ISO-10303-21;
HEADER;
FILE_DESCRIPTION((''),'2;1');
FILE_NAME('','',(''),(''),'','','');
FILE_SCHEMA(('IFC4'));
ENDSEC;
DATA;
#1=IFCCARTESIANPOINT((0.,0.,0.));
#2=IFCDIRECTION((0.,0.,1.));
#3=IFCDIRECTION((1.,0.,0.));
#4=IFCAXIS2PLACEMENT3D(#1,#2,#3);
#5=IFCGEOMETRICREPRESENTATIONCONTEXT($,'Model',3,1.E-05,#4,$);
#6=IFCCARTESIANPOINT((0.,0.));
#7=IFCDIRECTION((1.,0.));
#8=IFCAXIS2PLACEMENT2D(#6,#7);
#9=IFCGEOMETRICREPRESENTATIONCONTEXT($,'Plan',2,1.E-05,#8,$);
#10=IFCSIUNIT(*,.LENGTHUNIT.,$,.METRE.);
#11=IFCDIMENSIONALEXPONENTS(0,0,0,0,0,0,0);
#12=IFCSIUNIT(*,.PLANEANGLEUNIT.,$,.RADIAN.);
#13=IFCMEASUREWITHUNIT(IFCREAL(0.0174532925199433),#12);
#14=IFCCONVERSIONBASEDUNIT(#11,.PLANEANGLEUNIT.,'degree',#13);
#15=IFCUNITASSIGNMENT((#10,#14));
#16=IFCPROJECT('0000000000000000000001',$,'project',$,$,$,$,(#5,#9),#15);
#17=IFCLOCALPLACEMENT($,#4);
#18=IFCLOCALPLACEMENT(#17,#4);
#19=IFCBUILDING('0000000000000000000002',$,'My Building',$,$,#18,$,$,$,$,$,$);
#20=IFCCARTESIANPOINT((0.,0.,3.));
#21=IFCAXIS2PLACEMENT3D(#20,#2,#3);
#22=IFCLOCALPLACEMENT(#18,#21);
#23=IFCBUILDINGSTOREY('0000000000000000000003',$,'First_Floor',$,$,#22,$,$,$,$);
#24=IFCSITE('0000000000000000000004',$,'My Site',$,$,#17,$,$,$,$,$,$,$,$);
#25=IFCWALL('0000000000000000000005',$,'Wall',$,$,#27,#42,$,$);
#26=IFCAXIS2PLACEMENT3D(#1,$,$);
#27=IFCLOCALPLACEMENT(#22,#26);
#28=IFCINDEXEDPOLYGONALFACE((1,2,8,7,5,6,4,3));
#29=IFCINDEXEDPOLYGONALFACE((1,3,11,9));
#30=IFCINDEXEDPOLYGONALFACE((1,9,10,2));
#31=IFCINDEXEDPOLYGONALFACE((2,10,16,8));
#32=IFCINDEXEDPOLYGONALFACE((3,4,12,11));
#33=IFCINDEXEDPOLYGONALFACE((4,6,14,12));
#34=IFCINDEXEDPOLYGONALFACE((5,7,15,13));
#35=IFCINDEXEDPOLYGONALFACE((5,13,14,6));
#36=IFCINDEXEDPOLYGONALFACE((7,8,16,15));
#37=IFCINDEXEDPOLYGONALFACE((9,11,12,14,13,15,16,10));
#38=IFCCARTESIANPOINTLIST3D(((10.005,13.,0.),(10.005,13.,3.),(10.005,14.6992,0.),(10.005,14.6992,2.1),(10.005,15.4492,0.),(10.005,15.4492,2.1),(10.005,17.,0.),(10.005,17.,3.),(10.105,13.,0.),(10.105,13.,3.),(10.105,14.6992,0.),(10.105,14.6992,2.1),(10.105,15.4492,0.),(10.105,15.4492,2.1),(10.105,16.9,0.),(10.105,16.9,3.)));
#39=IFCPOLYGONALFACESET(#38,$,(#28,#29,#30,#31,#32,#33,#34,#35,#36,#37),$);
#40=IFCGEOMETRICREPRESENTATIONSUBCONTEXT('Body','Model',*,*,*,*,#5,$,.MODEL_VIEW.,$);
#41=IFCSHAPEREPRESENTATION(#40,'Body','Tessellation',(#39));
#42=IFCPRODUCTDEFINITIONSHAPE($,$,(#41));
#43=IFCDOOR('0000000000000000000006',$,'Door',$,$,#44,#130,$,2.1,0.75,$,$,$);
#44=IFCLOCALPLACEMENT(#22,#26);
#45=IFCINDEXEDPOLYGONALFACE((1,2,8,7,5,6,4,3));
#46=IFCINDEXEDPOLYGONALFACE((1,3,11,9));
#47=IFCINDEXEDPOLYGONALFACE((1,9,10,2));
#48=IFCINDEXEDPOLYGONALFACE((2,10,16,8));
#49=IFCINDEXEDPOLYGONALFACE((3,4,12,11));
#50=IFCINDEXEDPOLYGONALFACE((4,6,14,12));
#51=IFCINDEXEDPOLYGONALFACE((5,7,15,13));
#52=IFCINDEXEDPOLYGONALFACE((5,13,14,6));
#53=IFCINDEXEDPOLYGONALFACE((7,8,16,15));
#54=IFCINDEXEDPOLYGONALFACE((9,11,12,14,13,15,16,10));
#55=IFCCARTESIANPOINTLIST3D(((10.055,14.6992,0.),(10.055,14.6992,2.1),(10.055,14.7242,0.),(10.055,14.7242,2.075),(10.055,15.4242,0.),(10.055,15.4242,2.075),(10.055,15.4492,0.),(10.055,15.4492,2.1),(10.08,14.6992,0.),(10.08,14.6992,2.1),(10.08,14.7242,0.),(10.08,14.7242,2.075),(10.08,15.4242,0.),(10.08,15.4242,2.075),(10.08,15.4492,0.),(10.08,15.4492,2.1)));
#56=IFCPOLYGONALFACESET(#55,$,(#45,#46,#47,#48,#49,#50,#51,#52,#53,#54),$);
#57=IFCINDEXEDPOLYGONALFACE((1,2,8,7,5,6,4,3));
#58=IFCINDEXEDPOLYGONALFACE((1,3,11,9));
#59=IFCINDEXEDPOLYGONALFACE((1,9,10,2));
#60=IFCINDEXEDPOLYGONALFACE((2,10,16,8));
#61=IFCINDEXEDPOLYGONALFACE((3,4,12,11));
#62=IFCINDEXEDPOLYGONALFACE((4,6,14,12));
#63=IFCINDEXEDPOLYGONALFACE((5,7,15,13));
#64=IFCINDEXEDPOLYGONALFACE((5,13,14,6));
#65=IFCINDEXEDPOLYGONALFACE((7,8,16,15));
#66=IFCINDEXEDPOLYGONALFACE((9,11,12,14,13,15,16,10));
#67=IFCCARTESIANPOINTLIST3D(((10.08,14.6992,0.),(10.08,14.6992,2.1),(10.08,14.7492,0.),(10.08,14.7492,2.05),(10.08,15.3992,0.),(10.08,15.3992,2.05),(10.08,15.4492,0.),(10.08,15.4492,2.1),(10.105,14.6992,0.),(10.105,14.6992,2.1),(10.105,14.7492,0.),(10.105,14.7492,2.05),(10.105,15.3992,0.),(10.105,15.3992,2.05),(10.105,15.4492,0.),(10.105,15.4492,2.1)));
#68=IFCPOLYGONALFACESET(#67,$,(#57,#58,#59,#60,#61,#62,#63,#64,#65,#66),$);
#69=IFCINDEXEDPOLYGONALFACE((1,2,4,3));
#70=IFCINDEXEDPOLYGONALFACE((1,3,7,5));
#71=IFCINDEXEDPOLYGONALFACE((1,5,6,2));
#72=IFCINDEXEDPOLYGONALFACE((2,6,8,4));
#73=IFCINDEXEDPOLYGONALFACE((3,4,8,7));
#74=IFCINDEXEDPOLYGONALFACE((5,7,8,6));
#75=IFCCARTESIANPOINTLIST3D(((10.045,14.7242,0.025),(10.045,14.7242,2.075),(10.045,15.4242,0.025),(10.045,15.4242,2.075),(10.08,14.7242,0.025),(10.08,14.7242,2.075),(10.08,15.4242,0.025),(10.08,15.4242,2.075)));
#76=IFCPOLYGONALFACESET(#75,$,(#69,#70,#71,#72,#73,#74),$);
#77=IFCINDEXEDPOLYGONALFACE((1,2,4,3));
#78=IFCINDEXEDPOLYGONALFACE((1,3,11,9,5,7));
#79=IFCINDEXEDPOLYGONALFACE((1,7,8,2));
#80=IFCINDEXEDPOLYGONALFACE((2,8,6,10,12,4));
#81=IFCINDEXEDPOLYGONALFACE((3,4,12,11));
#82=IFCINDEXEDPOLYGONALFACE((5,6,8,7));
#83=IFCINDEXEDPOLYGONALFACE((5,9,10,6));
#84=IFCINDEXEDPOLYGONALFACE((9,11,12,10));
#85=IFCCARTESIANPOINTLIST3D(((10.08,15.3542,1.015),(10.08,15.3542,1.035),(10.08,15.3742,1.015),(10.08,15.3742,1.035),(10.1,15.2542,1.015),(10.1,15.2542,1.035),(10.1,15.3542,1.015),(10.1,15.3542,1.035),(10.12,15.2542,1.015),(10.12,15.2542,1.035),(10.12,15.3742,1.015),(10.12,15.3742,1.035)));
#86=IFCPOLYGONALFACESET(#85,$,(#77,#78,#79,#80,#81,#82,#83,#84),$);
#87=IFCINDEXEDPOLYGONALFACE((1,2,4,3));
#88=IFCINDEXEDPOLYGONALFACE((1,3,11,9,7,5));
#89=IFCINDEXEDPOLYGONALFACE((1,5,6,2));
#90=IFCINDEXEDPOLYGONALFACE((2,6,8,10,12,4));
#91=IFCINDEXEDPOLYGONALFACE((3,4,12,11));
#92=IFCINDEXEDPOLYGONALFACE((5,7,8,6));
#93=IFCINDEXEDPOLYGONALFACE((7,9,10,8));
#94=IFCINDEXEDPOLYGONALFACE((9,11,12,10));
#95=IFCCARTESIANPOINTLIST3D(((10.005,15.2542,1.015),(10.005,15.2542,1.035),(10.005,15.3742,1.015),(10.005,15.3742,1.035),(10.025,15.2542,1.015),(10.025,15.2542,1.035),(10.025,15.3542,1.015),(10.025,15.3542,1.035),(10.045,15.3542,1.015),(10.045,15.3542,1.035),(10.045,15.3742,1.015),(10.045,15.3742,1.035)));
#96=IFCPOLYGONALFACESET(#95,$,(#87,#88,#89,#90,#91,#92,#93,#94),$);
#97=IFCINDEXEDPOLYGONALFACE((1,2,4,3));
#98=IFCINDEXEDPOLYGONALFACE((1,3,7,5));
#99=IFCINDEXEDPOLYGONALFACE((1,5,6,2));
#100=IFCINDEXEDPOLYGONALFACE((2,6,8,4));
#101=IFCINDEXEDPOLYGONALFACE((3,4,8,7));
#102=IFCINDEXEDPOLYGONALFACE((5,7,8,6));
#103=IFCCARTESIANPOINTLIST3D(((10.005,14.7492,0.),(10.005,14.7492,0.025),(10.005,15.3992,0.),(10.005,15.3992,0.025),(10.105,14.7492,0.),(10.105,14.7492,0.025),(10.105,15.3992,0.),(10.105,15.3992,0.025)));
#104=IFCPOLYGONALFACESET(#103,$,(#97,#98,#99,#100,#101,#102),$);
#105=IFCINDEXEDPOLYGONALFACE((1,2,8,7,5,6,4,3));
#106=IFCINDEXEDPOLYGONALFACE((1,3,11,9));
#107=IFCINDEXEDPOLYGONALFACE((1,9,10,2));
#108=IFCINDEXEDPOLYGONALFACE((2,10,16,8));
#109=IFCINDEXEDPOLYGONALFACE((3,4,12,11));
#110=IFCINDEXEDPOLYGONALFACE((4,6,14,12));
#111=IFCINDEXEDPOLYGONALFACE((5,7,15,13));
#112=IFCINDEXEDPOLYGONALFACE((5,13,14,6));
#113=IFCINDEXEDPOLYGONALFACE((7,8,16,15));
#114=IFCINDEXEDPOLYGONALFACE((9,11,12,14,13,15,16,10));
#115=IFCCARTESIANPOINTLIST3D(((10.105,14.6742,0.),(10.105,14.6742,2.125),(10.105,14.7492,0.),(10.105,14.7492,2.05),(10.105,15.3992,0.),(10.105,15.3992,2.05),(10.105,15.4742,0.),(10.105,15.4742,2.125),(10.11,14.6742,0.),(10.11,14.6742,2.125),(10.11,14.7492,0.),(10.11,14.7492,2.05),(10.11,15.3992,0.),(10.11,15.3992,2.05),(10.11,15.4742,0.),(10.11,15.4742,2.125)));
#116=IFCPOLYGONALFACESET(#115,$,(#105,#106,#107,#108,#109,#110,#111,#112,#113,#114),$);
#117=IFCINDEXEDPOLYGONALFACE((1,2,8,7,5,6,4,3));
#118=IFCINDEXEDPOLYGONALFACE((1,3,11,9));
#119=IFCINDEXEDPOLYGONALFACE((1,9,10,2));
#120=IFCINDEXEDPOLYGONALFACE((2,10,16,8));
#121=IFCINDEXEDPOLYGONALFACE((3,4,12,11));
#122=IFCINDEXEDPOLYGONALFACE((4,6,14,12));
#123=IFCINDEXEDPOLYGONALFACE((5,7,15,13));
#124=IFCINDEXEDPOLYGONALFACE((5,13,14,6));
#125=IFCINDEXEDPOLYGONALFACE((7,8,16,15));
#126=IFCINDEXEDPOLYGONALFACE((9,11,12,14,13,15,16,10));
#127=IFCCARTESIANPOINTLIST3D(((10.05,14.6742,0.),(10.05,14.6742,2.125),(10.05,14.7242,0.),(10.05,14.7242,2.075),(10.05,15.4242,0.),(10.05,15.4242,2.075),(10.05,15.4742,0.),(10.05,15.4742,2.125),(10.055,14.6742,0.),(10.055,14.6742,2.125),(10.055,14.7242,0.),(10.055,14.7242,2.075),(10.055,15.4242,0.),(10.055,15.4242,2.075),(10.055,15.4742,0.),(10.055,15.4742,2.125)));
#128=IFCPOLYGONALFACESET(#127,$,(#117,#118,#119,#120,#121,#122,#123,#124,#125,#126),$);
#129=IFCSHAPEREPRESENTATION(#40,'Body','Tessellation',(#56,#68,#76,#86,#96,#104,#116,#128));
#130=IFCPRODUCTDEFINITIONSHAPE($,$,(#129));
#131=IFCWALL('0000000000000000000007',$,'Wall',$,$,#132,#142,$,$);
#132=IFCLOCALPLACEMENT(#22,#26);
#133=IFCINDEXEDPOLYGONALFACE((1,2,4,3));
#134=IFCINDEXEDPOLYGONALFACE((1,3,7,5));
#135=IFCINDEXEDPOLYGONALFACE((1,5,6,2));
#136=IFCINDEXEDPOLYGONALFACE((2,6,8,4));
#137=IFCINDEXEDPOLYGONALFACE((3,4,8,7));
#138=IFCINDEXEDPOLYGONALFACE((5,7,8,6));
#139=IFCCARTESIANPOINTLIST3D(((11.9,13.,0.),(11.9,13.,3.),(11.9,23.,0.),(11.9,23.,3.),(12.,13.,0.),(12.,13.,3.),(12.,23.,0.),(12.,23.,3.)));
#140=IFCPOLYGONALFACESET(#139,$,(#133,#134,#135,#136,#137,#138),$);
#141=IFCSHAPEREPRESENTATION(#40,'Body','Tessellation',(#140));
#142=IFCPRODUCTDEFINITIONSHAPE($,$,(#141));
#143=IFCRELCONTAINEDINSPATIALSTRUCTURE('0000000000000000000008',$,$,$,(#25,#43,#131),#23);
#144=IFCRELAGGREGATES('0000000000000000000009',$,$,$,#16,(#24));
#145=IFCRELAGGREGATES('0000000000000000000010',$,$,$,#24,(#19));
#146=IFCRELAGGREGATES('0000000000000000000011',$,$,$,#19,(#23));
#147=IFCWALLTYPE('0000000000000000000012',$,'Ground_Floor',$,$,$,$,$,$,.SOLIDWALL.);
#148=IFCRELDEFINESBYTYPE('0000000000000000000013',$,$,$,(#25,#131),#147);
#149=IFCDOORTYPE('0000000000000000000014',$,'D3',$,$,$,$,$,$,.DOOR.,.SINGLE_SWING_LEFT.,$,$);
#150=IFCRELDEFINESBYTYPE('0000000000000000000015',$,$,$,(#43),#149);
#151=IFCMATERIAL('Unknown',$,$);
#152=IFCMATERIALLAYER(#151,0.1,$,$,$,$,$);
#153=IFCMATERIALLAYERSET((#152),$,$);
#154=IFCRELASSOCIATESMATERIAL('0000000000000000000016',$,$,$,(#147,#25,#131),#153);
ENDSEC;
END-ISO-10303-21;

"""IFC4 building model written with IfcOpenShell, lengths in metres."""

from ifc_helpers import new_model, entity, si_unit, converted_unit, frame, origin_with_axes, origin_2d_with_axis, place, context, subcontext, project, spatial, line, indexed_curve, outline, extrude, shape, source, transform, mapped, material, layer, layer_set, layer_usage, type_object, type_shapes, element, fill, save


model = new_model("IFC4")

# Units and contexts
model_context = context("Model", 3, precision=1e-05, world=origin_with_axes())
plan_context = context("Plan", 2, precision=1e-05, world=origin_2d_with_axis())
body_context_1 = subcontext(model_context, "Body", "Model", "MODEL_VIEW")
body_context_2 = subcontext(plan_context, "Body", "Plan", "PLAN_VIEW")
ifc_project = project(units=[si_unit("LENGTHUNIT", "METRE"), converted_unit("PLANEANGLEUNIT", "degree", entity("IfcReal", 0.0174532925199433), si_unit("PLANEANGLEUNIT", "RADIAN"), dimensions=[0, 0, 0, 0, 0, 0, 0])], contexts=[model_context, plan_context])

# Site, building, storey
site_placement = place(None, origin_with_axes())
site = spatial("IfcSite", under=ifc_project, at=site_placement, Name="My Site")
building_placement = place(site_placement, origin_with_axes())
building = spatial("IfcBuilding", under=site, at=building_placement, Name="My Building")
storey_placement = place(building_placement, frame((0.0, 0.0, 3.0), z_axis=(0.0, 0.0, 1.0), x_axis=(1.0, 0.0, 0.0)))
storey = spatial("IfcBuildingStorey", under=building, at=storey_placement, Name="First_Floor")

# Shared definitions
ifc_material = material(Name="Unknown")

# Wall, opening, door
ifc_layer = layer(ifc_material, 0.1)
ifc_layer_set = layer_set([ifc_layer])
wall_type = type_object("IfcWallType", Name="Ground_Floor", PredefinedType="SOLIDWALL", material=ifc_layer_set)
ifc_layer_usage_1 = layer_usage(ifc_layer_set, "AXIS2", "POSITIVE", 0.0)
wall_1_placement = place(storey_placement, frame((10.005, 17.0, 0.0), z_axis=(0.0, 0.0, 1.0), x_axis=(0.0, -1.0, 0.0)))
wall_1 = element("IfcWall", 1, at=wall_1_placement, inside=storey, type_object=wall_type, material=ifc_layer_usage_1, Name="Wall", context=body_context_1, shape_type="SweptSolid", body=[
    extrude(outline(indexed_curve([(0.0, 0.0), (0.1, 0.1), (4.0, 0.1), (4.0, 0.0)], segments=[line(1, 2, 3, 4, 1)])), origin_with_axes(), (0.0, 0.0, 1.0), 3.0),
])
shared_shape_1 = source(origin_with_axes(), body_context_1, "Body", "SweptSolid", [
    extrude(outline(indexed_curve([(0.0, 0.0), (0.75, 0.0), (0.75, 2.1), (0.0, 2.1)], segments=[line(1, 2, 3, 4, 1)])), frame((0.0, -0.6, 0.0), z_axis=(0.0, -1.0, 0.0), x_axis=(1.0, 0.0, 0.0)), (0.0, 0.0, -1.0), 1.2),
])
opening_1_placement = place(wall_1_placement, frame((2.3008, 0.1, 0.0), z_axis=(0.0, 0.0, 1.0), x_axis=(-1.0, 0.0, 0.0)))
opening_1 = element("IfcOpeningElement", 2, at=opening_1_placement, cuts=wall_1, PredefinedType="OPENING", context=body_context_1, shape_type="MappedRepresentation", body=[
    mapped(shared_shape_1, transform((0.0, 0.0, 0.0), x_axis=(1.0, 0.0, 0.0), y_axis=(0.0, 1.0, 0.0), z_axis=(0.0, 0.0, 1.0), scale=1.0)),
])
door_type_1 = type_object("IfcDoorType", Name="D3", OperationType="SINGLE_SWING_LEFT", PredefinedType="DOOR")
shared_shape_2 = source(origin_with_axes(), body_context_1, "Body", "SweptSolid", [
    extrude(outline(indexed_curve([(0.0, 0.0), (0.0, 2.1), (0.75, 2.1), (0.75, 0.0), (0.725, 0.0), (0.725, 2.075), (0.025, 2.075), (0.025, 0.0)], segments=[line(1, 2, 3, 4, 5, 6, 7, 8, 1)])), frame((0.0, 0.025, 0.0), z_axis=(0.0, -1.0, 0.0), x_axis=(1.0, 0.0, 0.0)), (0.0, 0.0, -1.0), 0.025),
    extrude(outline(indexed_curve([(0.0, 0.0), (0.0, 2.1), (0.75, 2.1), (0.75, 0.0), (0.7, 0.0), (0.7, 2.05), (0.05, 2.05), (0.05, 0.0)], segments=[line(1, 2, 3, 4, 5, 6, 7, 8, 1)])), frame((0.0, 0.0, 0.0), z_axis=(0.0, -1.0, 0.0), x_axis=(1.0, 0.0, 0.0)), (0.0, 0.0, -1.0), 0.025),
    extrude(outline(indexed_curve([(0.0, 0.0), (0.7, 0.0), (0.7, 0.035), (0.0, 0.035)], segments=[line(1, 2, 3, 4, 1)])), frame((0.025, 0.025, 0.025), z_axis=(0.0, 0.0, 1.0), x_axis=(1.0, 0.0, 0.0)), (0.0, 0.0, 1.0), 2.05),
    extrude(outline(indexed_curve([(0.0, 0.0), (0.0, -0.04), (-0.12, -0.04), (-0.12, -0.02), (-0.02, -0.02), (-0.02, 0.0)], segments=[line(1, 2, 3, 4, 5, 6, 1)])), frame((0.675, 0.025, 1.015), z_axis=(0.0, 0.0, 1.0), x_axis=(1.0, 0.0, 0.0)), (0.0, 0.0, 1.0), 0.02),
    extrude(outline(indexed_curve([(0.0, 0.0), (0.0, 0.04), (-0.12, 0.04), (-0.12, 0.02), (-0.02, 0.02), (-0.02, 0.0)], segments=[line(1, 2, 3, 4, 5, 6, 1)])), frame((0.675, 0.06, 1.015), z_axis=(0.0, 0.0, 1.0), x_axis=(1.0, 0.0, 0.0)), (0.0, 0.0, 1.0), 0.02),
    extrude(outline(indexed_curve([(0.0, 0.0), (0.65, 0.0), (0.65, 0.1), (0.0, 0.1)], segments=[line(1, 2, 3, 4, 1)])), frame((0.05, 0.0, 0.0), z_axis=(0.0, 0.0, 1.0), x_axis=(1.0, 0.0, 0.0)), (0.0, 0.0, 1.0), 0.025),
    extrude(outline(indexed_curve([(0.0, 0.0), (0.0, 2.125), (0.8, 2.125), (0.8, 0.0), (0.725, 0.0), (0.725, 2.05), (0.075, 2.05), (0.075, 0.0)], segments=[line(1, 2, 3, 4, 5, 6, 7, 8, 1)])), frame((-0.025, -0.005, 0.0), z_axis=(0.0, -1.0, 0.0), x_axis=(1.0, 0.0, 0.0)), (0.0, 0.0, -1.0), 0.005),
    extrude(outline(indexed_curve([(0.0, 0.0), (0.0, 2.125), (0.8, 2.125), (0.8, 0.0), (0.75, 0.0), (0.75, 2.075), (0.05, 2.075), (0.05, 0.0)], segments=[line(1, 2, 3, 4, 5, 6, 7, 8, 1)])), frame((-0.025, 0.05, 0.0), z_axis=(0.0, -1.0, 0.0), x_axis=(1.0, 0.0, 0.0)), (0.0, 0.0, -1.0), 0.005),
])
shared_shape_3 = source(origin_with_axes(), body_context_2, "Body", "Curve2D", [
    entity("IfcIndexedPolyCurve", entity("IfcCartesianPointList2D", [[0.0, 0.0], [0.0, 0.05], [0.025, 0.05], [0.025, 0.025], [0.05, 0.025], [0.05, 0.0]]), [entity("IfcLineIndex", [1, 2, 3, 4, 5, 6, 1])]),
    entity("IfcIndexedPolyCurve", entity("IfcCartesianPointList2D", [[0.75, 0.0], [0.75, 0.05], [0.725, 0.05], [0.725, 0.025], [0.7, 0.025], [0.7, 0.0]]), [entity("IfcLineIndex", [1, 2, 3, 4, 5, 6, 1])]),
    entity("IfcTrimmedCurve", entity("IfcEllipse", entity("IfcAxis2Placement2D", entity("IfcCartesianPoint", [0.06, 0.05]), entity("IfcDirection", [1.0, 0.0])), 0.665, 0.7), [entity("IfcCartesianPoint", [0.725, 0.05])], [entity("IfcCartesianPoint", [0.06, 0.75])], True, "CARTESIAN"),
    entity("IfcIndexedPolyCurve", entity("IfcCartesianPointList2D", [[0.025, 0.05], [0.06, 0.05], [0.06, 0.75], [0.025, 0.75]]), [entity("IfcLineIndex", [1, 2, 3, 4, 1])]),
])
type_shapes(door_type_1, [shared_shape_2, shared_shape_3])
door_1_placement = place(opening_1_placement, frame((0.0, 0.0, 0.0), z_axis=(0.0, 0.0, 1.0), x_axis=(1.0, 0.0, 0.0)))
door_1 = element("IfcDoor", 3, at=door_1_placement, inside=storey, type_object=door_type_1, Name="Door", OverallHeight=2.1, OverallWidth=0.75, shapes=[
    shape(body_context_1, "Body", "MappedRepresentation", [mapped(shared_shape_2, transform((0.0, 0.0, 0.0), x_axis=(1.0, 0.0, 0.0), y_axis=(0.0, 1.0, 0.0), z_axis=(0.0, 0.0, 1.0), scale=1.0))]),
    shape(body_context_2, "Body", "MappedRepresentation", [mapped(shared_shape_3, transform((0.0, 0.0, 0.0), x_axis=(1.0, 0.0, 0.0), y_axis=(0.0, 1.0, 0.0), z_axis=(0.0, 0.0, 1.0), scale=1.0))]),
])
fill(opening_1, door_1)

# Wall
ifc_layer_usage_2 = layer_usage(ifc_layer_set, "AXIS2", "POSITIVE", 0.0)
wall_2_placement = place(storey_placement, frame((11.9, 23.0, 0.0), z_axis=(0.0, 0.0, 1.0), x_axis=(0.0, -1.0, 0.0)))
element("IfcWall", 4, at=wall_2_placement, inside=storey, type_object=wall_type, material=ifc_layer_usage_2, Name="Wall", context=body_context_1, shape_type="SweptSolid", body=[
    extrude(outline(indexed_curve([(0.0, 0.0), (0.0, 0.1), (10.0, 0.1), (10.0, 0.0)], segments=[line(1, 2, 3, 4, 1)])), origin_with_axes(), (0.0, 0.0, 1.0), 3.0),
])

save(model, "model.ifc")
